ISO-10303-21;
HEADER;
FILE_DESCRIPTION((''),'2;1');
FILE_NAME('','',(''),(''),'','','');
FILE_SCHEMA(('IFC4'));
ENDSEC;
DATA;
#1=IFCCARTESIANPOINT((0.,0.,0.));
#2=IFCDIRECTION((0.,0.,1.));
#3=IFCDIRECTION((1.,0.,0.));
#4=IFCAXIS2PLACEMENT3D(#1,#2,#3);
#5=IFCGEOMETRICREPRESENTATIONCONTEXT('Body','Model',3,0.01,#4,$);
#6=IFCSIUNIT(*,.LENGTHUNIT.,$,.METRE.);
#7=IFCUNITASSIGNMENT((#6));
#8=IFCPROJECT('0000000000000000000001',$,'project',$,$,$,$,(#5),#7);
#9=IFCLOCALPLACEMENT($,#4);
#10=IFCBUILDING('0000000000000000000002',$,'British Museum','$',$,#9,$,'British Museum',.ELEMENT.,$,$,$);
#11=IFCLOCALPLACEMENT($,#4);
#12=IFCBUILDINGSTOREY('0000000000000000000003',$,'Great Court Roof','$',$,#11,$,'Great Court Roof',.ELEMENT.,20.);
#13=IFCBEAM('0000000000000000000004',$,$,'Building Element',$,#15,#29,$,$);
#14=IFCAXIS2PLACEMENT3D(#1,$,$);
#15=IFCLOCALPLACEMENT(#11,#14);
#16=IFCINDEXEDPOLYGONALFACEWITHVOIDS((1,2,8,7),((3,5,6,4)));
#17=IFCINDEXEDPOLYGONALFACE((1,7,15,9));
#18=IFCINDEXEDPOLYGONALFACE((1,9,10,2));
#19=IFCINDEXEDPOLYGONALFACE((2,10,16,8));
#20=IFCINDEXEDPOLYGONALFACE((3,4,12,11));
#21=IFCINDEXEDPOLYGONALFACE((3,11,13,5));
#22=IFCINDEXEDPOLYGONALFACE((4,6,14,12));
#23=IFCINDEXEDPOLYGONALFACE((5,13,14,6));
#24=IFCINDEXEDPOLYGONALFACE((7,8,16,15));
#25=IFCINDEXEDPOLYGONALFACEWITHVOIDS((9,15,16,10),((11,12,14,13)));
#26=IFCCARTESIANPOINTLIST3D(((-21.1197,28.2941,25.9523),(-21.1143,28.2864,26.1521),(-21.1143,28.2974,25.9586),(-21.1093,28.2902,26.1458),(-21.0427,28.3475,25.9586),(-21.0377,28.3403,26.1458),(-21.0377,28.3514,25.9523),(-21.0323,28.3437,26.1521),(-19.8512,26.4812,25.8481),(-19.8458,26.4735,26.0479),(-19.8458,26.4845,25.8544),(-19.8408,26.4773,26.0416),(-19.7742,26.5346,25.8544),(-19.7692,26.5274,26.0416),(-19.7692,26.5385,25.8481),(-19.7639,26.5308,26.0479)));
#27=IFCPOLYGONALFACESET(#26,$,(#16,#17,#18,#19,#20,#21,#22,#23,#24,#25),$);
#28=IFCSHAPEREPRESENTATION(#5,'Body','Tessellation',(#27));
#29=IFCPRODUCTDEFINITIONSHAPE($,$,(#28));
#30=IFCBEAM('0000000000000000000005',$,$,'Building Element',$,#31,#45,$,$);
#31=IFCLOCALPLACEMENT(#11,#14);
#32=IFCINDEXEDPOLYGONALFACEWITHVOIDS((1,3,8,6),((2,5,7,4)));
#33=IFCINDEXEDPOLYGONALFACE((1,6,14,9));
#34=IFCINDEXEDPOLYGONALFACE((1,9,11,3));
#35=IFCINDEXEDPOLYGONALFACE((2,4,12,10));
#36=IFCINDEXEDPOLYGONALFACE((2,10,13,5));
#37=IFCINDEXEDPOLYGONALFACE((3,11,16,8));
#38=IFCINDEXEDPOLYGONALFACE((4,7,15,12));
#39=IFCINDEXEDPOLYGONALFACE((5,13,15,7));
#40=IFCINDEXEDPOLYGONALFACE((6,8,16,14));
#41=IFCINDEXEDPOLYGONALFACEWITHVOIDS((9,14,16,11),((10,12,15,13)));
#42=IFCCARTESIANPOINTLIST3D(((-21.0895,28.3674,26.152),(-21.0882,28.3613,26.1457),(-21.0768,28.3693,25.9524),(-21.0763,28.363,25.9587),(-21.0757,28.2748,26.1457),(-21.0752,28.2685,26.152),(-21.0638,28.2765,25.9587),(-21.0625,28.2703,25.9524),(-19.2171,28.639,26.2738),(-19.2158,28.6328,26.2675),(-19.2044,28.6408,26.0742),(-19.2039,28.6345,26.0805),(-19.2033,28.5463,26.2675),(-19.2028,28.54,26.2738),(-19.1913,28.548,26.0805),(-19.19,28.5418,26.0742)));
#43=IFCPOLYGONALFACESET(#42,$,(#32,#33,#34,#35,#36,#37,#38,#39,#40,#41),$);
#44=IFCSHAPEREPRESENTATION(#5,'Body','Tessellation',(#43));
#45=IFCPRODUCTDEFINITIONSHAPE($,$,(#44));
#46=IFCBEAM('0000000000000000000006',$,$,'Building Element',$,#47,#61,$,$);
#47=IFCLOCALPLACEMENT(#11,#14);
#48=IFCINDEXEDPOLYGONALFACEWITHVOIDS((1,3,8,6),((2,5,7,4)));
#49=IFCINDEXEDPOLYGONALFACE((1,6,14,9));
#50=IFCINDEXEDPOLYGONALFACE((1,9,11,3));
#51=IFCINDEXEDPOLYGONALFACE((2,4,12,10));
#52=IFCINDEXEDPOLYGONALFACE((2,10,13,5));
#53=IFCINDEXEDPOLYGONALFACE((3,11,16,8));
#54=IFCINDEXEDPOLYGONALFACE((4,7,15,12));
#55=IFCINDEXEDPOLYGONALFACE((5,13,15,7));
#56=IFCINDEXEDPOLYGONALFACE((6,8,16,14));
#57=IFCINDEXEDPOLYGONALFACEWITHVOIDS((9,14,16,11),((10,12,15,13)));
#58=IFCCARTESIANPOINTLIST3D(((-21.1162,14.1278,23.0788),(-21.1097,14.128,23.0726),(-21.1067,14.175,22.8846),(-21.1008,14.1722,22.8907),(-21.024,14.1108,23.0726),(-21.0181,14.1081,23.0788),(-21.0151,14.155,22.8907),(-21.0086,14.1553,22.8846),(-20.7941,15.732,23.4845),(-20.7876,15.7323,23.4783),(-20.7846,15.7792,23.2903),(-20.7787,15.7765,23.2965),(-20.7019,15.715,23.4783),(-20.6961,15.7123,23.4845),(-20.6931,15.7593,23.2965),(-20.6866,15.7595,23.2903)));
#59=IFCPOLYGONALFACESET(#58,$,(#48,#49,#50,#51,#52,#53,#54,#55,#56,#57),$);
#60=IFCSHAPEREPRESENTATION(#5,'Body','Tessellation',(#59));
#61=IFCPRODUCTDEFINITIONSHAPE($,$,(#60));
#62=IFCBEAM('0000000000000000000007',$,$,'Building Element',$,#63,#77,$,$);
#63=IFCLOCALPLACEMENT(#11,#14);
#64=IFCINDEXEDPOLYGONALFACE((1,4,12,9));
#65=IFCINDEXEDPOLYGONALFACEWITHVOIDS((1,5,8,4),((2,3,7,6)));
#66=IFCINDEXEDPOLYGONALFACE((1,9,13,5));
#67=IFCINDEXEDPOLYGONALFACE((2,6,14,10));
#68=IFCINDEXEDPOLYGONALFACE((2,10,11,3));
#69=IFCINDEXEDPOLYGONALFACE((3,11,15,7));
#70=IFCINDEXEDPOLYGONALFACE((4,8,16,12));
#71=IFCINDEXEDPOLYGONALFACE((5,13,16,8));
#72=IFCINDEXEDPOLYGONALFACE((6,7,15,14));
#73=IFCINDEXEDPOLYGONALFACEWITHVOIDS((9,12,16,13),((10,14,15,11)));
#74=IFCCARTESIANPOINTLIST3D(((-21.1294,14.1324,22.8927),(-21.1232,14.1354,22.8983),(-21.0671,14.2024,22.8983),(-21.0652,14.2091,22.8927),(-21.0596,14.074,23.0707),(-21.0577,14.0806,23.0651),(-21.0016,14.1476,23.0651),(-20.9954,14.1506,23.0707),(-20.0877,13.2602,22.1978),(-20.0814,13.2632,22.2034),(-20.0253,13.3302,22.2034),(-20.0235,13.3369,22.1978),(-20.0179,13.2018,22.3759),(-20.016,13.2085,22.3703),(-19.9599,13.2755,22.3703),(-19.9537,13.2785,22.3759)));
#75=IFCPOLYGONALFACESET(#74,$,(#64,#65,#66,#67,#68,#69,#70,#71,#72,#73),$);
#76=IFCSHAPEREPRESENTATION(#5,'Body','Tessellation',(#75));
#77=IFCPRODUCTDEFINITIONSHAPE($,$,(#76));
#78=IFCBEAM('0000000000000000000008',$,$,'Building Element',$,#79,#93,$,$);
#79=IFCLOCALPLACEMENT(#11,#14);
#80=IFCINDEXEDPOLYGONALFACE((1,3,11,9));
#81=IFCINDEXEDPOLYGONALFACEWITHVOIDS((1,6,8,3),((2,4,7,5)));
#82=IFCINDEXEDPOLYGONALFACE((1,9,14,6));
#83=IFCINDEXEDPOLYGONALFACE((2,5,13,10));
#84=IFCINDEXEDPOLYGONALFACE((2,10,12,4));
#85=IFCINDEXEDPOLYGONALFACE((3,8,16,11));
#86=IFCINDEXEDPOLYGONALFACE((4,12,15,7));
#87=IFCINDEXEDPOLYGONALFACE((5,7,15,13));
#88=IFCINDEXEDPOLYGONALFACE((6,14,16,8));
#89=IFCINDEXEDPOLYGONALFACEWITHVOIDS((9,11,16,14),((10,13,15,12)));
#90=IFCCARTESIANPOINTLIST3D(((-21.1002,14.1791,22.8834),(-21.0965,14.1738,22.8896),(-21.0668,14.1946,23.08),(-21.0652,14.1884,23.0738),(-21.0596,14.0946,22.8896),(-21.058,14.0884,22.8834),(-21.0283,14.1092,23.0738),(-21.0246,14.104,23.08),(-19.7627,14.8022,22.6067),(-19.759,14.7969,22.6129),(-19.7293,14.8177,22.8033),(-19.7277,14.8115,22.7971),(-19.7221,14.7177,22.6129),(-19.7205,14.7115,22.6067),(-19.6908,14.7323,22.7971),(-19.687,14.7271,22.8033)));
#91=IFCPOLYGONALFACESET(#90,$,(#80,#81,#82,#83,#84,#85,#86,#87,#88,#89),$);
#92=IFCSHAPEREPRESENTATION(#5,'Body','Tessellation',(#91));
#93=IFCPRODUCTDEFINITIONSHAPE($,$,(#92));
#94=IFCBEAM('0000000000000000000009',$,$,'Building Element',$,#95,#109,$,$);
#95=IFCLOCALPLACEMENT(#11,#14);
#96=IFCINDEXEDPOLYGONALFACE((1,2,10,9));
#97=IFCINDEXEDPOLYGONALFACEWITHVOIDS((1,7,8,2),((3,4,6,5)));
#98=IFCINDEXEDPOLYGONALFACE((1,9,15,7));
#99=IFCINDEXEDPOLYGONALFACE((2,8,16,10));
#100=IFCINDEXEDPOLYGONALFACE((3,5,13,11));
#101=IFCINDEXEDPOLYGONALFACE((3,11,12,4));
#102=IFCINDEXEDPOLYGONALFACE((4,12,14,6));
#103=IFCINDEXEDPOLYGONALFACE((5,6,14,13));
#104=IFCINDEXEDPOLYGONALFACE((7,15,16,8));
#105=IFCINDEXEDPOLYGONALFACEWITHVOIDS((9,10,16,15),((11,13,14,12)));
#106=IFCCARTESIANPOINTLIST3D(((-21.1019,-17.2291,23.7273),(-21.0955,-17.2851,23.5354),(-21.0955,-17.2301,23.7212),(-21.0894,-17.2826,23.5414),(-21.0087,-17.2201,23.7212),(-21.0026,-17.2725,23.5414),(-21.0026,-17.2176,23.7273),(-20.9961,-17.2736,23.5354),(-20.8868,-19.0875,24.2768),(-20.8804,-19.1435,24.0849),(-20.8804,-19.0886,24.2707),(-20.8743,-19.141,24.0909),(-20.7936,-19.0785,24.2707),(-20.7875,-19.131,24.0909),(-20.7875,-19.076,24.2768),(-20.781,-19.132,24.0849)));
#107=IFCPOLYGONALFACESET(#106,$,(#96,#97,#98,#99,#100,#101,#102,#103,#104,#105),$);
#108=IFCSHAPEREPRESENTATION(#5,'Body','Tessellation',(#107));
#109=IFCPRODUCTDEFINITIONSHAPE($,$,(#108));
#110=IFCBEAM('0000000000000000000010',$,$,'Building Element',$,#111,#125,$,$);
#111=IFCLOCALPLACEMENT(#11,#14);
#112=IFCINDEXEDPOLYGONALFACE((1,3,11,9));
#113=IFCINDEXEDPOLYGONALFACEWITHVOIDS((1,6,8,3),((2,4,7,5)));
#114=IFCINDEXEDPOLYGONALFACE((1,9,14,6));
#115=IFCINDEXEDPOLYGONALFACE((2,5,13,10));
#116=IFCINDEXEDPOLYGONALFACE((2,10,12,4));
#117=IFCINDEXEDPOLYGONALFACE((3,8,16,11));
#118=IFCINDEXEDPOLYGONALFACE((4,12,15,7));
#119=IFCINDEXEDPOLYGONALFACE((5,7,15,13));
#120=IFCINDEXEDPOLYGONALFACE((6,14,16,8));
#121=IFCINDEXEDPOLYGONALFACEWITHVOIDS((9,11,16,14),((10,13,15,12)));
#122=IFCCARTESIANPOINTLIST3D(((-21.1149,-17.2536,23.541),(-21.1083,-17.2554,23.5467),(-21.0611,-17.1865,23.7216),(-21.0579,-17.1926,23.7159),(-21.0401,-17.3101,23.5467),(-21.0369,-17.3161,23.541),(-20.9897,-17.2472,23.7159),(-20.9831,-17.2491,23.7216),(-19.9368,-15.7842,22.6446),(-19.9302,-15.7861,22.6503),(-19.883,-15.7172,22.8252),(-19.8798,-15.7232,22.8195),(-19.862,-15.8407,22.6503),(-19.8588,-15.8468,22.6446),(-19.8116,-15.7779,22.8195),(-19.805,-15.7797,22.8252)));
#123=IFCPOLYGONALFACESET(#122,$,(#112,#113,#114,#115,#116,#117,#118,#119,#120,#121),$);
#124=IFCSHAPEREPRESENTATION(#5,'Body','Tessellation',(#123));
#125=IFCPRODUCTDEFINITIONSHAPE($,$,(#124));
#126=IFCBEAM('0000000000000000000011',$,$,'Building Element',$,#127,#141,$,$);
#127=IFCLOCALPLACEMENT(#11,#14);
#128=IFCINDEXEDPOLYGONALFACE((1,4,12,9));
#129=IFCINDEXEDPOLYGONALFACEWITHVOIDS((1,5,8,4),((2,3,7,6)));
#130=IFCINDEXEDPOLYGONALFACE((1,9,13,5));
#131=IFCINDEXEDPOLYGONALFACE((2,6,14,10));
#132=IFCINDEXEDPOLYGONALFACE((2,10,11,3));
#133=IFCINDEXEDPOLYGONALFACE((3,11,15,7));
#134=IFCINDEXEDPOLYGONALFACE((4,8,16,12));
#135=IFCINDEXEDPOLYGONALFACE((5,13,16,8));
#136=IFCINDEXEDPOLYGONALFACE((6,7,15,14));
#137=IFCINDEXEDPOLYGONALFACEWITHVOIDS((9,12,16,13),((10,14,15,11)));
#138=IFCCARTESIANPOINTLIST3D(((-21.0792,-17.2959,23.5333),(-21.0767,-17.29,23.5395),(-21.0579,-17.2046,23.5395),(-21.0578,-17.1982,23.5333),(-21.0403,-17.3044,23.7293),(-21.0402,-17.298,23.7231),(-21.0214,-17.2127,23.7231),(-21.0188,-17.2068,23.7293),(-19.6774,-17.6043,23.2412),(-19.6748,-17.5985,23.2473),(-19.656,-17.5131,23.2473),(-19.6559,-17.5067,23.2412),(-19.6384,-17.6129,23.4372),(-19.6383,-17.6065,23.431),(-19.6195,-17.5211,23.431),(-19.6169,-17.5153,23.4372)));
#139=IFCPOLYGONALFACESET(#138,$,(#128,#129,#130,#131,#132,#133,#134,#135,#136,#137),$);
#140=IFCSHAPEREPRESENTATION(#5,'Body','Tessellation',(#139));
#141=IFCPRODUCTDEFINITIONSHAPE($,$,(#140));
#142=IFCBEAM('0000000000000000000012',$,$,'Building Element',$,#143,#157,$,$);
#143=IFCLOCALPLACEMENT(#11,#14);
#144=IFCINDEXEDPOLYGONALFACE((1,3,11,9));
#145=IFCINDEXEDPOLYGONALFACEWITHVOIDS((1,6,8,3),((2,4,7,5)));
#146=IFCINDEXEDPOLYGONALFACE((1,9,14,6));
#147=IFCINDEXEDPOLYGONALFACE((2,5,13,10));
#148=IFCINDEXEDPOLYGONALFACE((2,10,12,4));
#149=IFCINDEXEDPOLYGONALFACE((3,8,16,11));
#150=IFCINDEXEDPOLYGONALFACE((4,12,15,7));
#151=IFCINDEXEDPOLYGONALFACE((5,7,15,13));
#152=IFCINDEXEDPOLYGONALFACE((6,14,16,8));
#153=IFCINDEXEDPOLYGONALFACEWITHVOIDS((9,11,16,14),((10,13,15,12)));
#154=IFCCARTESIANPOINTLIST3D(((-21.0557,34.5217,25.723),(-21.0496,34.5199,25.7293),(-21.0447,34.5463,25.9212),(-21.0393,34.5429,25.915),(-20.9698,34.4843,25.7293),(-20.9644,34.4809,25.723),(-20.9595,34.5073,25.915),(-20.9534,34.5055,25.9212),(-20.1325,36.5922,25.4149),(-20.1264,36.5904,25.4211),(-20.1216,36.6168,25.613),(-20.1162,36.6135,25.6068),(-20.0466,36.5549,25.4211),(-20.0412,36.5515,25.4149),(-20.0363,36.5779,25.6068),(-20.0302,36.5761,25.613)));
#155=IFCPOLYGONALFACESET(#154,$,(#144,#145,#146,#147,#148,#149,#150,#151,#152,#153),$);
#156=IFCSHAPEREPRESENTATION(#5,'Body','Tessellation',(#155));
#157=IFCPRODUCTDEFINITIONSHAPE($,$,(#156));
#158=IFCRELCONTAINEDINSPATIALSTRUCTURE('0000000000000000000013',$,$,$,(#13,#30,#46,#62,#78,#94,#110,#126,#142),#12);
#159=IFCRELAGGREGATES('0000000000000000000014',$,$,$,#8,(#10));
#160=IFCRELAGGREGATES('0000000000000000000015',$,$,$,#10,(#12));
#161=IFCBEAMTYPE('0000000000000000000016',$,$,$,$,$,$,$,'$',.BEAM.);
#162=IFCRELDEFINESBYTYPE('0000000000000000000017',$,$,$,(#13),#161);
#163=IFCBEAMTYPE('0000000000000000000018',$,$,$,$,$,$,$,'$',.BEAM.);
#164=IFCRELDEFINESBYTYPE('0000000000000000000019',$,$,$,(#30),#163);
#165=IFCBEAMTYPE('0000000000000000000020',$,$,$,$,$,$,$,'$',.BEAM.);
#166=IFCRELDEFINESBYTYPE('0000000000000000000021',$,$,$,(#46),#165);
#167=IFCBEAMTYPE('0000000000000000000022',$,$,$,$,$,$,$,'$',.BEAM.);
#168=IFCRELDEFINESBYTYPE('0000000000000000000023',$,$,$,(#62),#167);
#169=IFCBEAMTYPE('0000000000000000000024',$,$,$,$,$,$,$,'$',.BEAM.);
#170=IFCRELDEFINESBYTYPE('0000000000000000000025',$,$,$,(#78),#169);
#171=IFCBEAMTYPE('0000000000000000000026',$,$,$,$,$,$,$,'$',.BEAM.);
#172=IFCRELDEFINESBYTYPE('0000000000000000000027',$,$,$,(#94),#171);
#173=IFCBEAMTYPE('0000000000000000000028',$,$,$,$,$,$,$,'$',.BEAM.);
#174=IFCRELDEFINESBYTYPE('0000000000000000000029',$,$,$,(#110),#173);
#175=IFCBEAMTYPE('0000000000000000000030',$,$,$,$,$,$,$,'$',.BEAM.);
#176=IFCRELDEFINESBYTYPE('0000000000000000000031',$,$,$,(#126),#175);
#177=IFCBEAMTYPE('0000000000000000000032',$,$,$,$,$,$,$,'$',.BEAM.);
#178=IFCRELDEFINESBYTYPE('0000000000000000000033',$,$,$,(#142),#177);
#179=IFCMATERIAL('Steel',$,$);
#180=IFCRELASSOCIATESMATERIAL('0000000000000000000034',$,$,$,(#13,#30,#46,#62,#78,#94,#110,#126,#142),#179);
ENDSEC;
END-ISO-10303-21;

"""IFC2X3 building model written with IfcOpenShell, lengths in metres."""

from ifc_helpers import new_model, si_unit, frame, origin_with_axes, origin_2d, place, context, project, spatial, hollow_rectangle, extrude, material, type_object, element, save


model = new_model("IFC2X3")

# Units and contexts
model_context = context("Model", 3, precision=0.01, world=origin_with_axes(), identifier="Body")
ifc_project = project(units=[si_unit("LENGTHUNIT", "METRE")], contexts=[model_context])

# Building, storey
building_placement = place(None, origin_with_axes())
building = spatial("IfcBuilding", under=ifc_project, at=building_placement, Name="British Museum", Description="$", LongName="British Museum", CompositionType="ELEMENT")
storey_placement = place(None, origin_with_axes())
storey = spatial("IfcBuildingStorey", under=building, at=storey_placement, Name="Great Court Roof", Description="$", LongName="Great Court Roof", CompositionType="ELEMENT", Elevation=20.0)

# Beams
ifc_material = material(Name="Steel")
beam_type_1 = type_object("IfcBeamType", ElementType="$", PredefinedType="BEAM")
beam_1_placement = place(None, origin_with_axes())
element("IfcBeam", 1, at=beam_1_placement, inside=storey, type_object=beam_type_1, material=ifc_material, Description="Building Element", context=model_context, shape_type="SweptSolid", body=[
    extrude(hollow_rectangle(XDim=0.1, YDim=0.2, WallThickness=0.0063, InnerFilletRadius=-0.0063, OuterFilletRadius=0.0, at=origin_2d()), frame((-21.076, 28.3189, 26.0522), z_axis=(0.572659, -0.818443, -0.047046), x_axis=(0.81935, 0.573294, 0.0)), (0.0, 0.0, 1.0), 2.2151),
])
beam_type_2 = type_object("IfcBeamType", ElementType="$", PredefinedType="BEAM")
beam_2_placement = place(None, origin_with_axes())
element("IfcBeam", 2, at=beam_2_placement, inside=storey, type_object=beam_type_2, material=ifc_material, Description="Building Element", context=model_context, shape_type="SweptSolid", body=[
    extrude(hollow_rectangle(XDim=0.1, YDim=0.2, WallThickness=0.0063, InnerFilletRadius=-0.0063, OuterFilletRadius=0.0, at=origin_2d()), frame((-21.076, 28.3189, 26.0522), z_axis=(0.987603, 0.143218, 0.064257), x_axis=(-0.143514, 0.989648, 0.0)), (0.0, 0.0, 1.0), 1.8959),
])
beam_type_3 = type_object("IfcBeamType", ElementType="$", PredefinedType="BEAM")
beam_3_placement = place(None, origin_with_axes())
element("IfcBeam", 3, at=beam_3_placement, inside=storey, type_object=beam_type_3, material=ifc_material, Description="Building Element", context=model_context, shape_type="SweptSolid", body=[
    extrude(hollow_rectangle(XDim=0.1, YDim=0.2, WallThickness=0.0063, InnerFilletRadius=-0.0063, OuterFilletRadius=0.0, at=origin_2d()), frame((-21.0624, 14.1415, 22.9817), z_axis=(0.191047, 0.951621, 0.240663), x_axis=(-0.980437, 0.196832, 0.0)), (0.0, 0.0, 1.0), 1.6858),
])
beam_type_4 = type_object("IfcBeamType", ElementType="$", PredefinedType="BEAM")
beam_4_placement = place(None, origin_with_axes())
element("IfcBeam", 4, at=beam_4_placement, inside=storey, type_object=beam_type_4, material=ifc_material, Description="Building Element", context=model_context, shape_type="SweptSolid", body=[
    extrude(hollow_rectangle(XDim=0.1, YDim=0.2, WallThickness=0.0063, InnerFilletRadius=-0.0063, OuterFilletRadius=0.0, at=origin_2d()), frame((-21.0624, 14.1415, 22.9817), z_axis=(0.68265, -0.571546, -0.455329), x_axis=(0.641953, 0.766744, 0.0)), (0.0, 0.0, 1.0), 1.526),
])
beam_type_5 = type_object("IfcBeamType", ElementType="$", PredefinedType="BEAM")
beam_5_placement = place(None, origin_with_axes())
element("IfcBeam", 5, at=beam_5_placement, inside=storey, type_object=beam_type_5, material=ifc_material, Description="Building Element", context=model_context, shape_type="SweptSolid", body=[
    extrude(hollow_rectangle(XDim=0.1, YDim=0.2, WallThickness=0.0063, InnerFilletRadius=-0.0063, OuterFilletRadius=0.0, at=origin_2d()), frame((-21.0624, 14.1415, 22.9817), z_axis=(0.890936, 0.415048, -0.184306), x_axis=(-0.422282, 0.906464, 0.0)), (0.0, 0.0, 1.0), 1.5013),
])
beam_type_6 = type_object("IfcBeamType", ElementType="$", PredefinedType="BEAM")
beam_6_placement = place(None, origin_with_axes())
element("IfcBeam", 6, at=beam_6_placement, inside=storey, type_object=beam_type_6, material=ifc_material, Description="Building Element", context=model_context, shape_type="SweptSolid", body=[
    extrude(hollow_rectangle(XDim=0.1, YDim=0.2, WallThickness=0.0063, InnerFilletRadius=-0.0063, OuterFilletRadius=0.0, at=origin_2d()), frame((-21.049, -17.2513, 23.6313), z_axis=(0.11031, -0.953106, 0.281815), x_axis=(0.993369, 0.11497, 0.0)), (0.0, 0.0, 1.0), 1.9499),
])
beam_type_7 = type_object("IfcBeamType", ElementType="$", PredefinedType="BEAM")
beam_7_placement = place(None, origin_with_axes())
element("IfcBeam", 7, at=beam_7_placement, inside=storey, type_object=beam_type_7, material=ifc_material, Description="Building Element", context=model_context, shape_type="SweptSolid", body=[
    extrude(hollow_rectangle(XDim=0.1, YDim=0.2, WallThickness=0.0063, InnerFilletRadius=-0.0063, OuterFilletRadius=0.0, at=origin_2d()), frame((-21.049, -17.2513, 23.6313), z_axis=(0.564836, 0.704457, -0.429769), x_axis=(-0.780182, 0.625553, 0.0)), (0.0, 0.0, 1.0), 2.0858),
])
beam_type_8 = type_object("IfcBeamType", ElementType="$", PredefinedType="BEAM")
beam_8_placement = place(None, origin_with_axes())
element("IfcBeam", 8, at=beam_8_placement, inside=storey, type_object=beam_type_8, material=ifc_material, Description="Building Element", context=model_context, shape_type="SweptSolid", body=[
    extrude(hollow_rectangle(XDim=0.1, YDim=0.2, WallThickness=0.0063, InnerFilletRadius=-0.0063, OuterFilletRadius=0.0, at=origin_2d()), frame((-21.049, -17.2513, 23.6313), z_axis=(0.957013, -0.210589, -0.199446), x_axis=(0.214907, 0.976635, 0.0)), (0.0, 0.0, 1.0), 1.4648),
])
beam_type_9 = type_object("IfcBeamType", ElementType="$", PredefinedType="BEAM")
beam_9_placement = place(None, origin_with_axes())
element("IfcBeam", 9, at=beam_9_placement, inside=storey, type_object=beam_type_9, material=ifc_material, Description="Building Element", context=model_context, shape_type="SweptSolid", body=[
    extrude(hollow_rectangle(XDim=0.1, YDim=0.2, WallThickness=0.0063, InnerFilletRadius=-0.0063, OuterFilletRadius=0.0, at=origin_2d()), frame((-21.0046, 34.5136, 25.8221), z_axis=(0.403501, 0.905011, -0.134691), x_axis=(-0.913334, 0.407211, 0.0)), (0.0, 0.0, 1.0), 2.2879),
])

save(model, "model.ifc")
